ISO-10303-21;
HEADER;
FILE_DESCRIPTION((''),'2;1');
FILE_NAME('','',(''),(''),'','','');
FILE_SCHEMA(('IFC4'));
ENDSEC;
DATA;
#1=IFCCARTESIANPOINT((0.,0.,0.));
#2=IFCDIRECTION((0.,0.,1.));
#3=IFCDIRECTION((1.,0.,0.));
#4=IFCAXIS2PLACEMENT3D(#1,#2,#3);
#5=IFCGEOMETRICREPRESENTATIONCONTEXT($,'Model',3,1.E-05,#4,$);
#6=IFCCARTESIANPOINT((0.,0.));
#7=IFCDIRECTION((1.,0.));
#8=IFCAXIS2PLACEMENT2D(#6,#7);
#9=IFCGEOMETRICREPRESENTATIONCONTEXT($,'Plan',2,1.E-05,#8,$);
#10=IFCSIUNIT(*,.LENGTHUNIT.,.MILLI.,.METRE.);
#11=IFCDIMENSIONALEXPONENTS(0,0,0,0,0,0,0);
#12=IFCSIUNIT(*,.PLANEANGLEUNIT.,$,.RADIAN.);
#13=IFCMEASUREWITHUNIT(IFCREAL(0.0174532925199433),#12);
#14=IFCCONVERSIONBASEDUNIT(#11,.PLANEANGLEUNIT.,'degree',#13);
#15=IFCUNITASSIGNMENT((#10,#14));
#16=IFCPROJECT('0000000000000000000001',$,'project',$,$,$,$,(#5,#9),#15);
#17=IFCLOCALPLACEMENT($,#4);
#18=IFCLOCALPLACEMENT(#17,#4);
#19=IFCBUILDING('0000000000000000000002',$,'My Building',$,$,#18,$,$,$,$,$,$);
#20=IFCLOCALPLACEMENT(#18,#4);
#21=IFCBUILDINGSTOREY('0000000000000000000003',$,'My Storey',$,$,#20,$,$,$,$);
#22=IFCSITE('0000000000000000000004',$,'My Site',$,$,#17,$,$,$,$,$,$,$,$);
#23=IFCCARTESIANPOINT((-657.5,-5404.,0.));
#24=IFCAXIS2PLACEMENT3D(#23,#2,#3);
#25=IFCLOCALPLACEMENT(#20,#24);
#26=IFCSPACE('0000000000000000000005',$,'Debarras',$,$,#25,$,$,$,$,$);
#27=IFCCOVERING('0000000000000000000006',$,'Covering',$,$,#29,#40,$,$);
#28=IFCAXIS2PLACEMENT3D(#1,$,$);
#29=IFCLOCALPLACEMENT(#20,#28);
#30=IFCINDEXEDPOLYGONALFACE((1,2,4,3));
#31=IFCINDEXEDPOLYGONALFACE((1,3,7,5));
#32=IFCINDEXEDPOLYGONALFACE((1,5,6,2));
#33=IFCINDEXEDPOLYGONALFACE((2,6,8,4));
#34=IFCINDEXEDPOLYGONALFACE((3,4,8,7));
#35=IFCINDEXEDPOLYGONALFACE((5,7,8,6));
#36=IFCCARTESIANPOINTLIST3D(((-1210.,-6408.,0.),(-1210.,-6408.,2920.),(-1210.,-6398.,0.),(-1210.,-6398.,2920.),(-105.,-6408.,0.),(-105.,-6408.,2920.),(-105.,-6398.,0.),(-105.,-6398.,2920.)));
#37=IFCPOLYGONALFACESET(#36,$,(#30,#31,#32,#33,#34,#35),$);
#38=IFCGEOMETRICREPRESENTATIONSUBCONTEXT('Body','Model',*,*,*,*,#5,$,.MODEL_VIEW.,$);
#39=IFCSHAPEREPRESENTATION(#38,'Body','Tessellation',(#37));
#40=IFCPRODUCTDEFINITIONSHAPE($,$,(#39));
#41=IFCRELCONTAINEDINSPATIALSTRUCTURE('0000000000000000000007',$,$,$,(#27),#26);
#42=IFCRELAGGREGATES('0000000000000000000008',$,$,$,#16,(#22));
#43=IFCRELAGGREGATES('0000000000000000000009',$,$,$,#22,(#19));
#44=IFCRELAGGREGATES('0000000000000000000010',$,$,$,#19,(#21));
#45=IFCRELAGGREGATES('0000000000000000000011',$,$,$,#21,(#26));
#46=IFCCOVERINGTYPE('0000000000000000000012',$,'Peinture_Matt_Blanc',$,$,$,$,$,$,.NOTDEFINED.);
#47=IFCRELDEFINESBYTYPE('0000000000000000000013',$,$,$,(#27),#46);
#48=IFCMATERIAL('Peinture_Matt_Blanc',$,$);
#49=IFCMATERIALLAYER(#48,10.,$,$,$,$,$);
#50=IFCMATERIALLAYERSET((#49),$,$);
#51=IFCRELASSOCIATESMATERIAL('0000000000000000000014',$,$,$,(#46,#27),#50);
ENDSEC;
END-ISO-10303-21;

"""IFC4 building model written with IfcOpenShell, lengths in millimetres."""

from ifc_helpers import new_model, entity, si_unit, converted_unit, frame, origin_with_axes, origin_2d_with_axis, place, context, subcontext, project, spatial, indexed_curve, outline, extrude, clip, halfspace, material, layer, layer_set, layer_usage, type_object, element, save


model = new_model("IFC4")

# Units and contexts
model_context = context("Model", 3, precision=1e-05, world=origin_with_axes())
plan_context = context("Plan", 2, precision=1e-05, world=origin_2d_with_axis())
body_context_1 = subcontext(model_context, "Body", "Model", "MODEL_VIEW")
ifc_project = project(units=[si_unit("LENGTHUNIT", "METRE", prefix="MILLI"), converted_unit("PLANEANGLEUNIT", "degree", entity("IfcReal", 0.0174532925199433), si_unit("PLANEANGLEUNIT", "RADIAN"), dimensions=[0, 0, 0, 0, 0, 0, 0])], contexts=[model_context, plan_context])

# Site, building, storey
site_placement = place(None, origin_with_axes())
site = spatial("IfcSite", under=ifc_project, at=site_placement, Name="My Site")
building_placement = place(site_placement, origin_with_axes())
building = spatial("IfcBuilding", under=site, at=building_placement, Name="My Building")
storey_placement = place(building_placement, origin_with_axes())
storey = spatial("IfcBuildingStorey", under=building, at=storey_placement, Name="My Storey")

# Shared definitions
ifc_material_1 = material(Name="Peinture_Matt_Blanc")
ifc_layer_1 = layer(ifc_material_1, 10.0)
ifc_layer_set_1 = layer_set([ifc_layer_1])
covering_type_1 = type_object("IfcCoveringType", Name="Peinture_Matt_Blanc", PredefinedType="NOTDEFINED", material=ifc_layer_set_1)

# Shared definitions
space_1_placement = place(storey_placement, frame((-657.5, -5404.0, 0.0), z_axis=(0.0, 0.0, 1.0), x_axis=(1.0, 0.0, 0.0)))
space_1 = spatial("IfcSpace", under=storey, at=space_1_placement, Name="Debarras")

# Covering
ifc_layer_usage_1 = layer_usage(ifc_layer_set_1, "AXIS2", "POSITIVE", 0.0)
covering_1_placement = place(space_1_placement, frame((552.5, -994.0, 0.0), z_axis=(0.0, 0.0, 1.0), x_axis=(-1.0, 0.000003, 0.0)))
element("IfcCovering", 1, at=covering_1_placement, inside=space_1, type_object=covering_type_1, material=ifc_layer_usage_1, Name="Covering", context=body_context_1, shape_type="Clipping", body=[
    clip(clip(extrude(outline(indexed_curve([(0.0, 0.0), (0.0, 10.0), (1105.0, 10.0), (1105.0, 0.0), (0.0, 0.0)], self_intersect=False)), origin_with_axes(), (0.0, 0.0, 1.0), 2920.0), halfspace(frame((0.0, 0.0, 2920.0), z_axis=(0.0, 0.0, 1.0), x_axis=(-1.0, 0.0, 0.0)), False)), halfspace(frame((0.0, 0.0, 2920.0), z_axis=(0.0, 0.0, 1.0), x_axis=(-1.0, 0.0, 0.0)), False)),
])

save(model, "model.ifc")
